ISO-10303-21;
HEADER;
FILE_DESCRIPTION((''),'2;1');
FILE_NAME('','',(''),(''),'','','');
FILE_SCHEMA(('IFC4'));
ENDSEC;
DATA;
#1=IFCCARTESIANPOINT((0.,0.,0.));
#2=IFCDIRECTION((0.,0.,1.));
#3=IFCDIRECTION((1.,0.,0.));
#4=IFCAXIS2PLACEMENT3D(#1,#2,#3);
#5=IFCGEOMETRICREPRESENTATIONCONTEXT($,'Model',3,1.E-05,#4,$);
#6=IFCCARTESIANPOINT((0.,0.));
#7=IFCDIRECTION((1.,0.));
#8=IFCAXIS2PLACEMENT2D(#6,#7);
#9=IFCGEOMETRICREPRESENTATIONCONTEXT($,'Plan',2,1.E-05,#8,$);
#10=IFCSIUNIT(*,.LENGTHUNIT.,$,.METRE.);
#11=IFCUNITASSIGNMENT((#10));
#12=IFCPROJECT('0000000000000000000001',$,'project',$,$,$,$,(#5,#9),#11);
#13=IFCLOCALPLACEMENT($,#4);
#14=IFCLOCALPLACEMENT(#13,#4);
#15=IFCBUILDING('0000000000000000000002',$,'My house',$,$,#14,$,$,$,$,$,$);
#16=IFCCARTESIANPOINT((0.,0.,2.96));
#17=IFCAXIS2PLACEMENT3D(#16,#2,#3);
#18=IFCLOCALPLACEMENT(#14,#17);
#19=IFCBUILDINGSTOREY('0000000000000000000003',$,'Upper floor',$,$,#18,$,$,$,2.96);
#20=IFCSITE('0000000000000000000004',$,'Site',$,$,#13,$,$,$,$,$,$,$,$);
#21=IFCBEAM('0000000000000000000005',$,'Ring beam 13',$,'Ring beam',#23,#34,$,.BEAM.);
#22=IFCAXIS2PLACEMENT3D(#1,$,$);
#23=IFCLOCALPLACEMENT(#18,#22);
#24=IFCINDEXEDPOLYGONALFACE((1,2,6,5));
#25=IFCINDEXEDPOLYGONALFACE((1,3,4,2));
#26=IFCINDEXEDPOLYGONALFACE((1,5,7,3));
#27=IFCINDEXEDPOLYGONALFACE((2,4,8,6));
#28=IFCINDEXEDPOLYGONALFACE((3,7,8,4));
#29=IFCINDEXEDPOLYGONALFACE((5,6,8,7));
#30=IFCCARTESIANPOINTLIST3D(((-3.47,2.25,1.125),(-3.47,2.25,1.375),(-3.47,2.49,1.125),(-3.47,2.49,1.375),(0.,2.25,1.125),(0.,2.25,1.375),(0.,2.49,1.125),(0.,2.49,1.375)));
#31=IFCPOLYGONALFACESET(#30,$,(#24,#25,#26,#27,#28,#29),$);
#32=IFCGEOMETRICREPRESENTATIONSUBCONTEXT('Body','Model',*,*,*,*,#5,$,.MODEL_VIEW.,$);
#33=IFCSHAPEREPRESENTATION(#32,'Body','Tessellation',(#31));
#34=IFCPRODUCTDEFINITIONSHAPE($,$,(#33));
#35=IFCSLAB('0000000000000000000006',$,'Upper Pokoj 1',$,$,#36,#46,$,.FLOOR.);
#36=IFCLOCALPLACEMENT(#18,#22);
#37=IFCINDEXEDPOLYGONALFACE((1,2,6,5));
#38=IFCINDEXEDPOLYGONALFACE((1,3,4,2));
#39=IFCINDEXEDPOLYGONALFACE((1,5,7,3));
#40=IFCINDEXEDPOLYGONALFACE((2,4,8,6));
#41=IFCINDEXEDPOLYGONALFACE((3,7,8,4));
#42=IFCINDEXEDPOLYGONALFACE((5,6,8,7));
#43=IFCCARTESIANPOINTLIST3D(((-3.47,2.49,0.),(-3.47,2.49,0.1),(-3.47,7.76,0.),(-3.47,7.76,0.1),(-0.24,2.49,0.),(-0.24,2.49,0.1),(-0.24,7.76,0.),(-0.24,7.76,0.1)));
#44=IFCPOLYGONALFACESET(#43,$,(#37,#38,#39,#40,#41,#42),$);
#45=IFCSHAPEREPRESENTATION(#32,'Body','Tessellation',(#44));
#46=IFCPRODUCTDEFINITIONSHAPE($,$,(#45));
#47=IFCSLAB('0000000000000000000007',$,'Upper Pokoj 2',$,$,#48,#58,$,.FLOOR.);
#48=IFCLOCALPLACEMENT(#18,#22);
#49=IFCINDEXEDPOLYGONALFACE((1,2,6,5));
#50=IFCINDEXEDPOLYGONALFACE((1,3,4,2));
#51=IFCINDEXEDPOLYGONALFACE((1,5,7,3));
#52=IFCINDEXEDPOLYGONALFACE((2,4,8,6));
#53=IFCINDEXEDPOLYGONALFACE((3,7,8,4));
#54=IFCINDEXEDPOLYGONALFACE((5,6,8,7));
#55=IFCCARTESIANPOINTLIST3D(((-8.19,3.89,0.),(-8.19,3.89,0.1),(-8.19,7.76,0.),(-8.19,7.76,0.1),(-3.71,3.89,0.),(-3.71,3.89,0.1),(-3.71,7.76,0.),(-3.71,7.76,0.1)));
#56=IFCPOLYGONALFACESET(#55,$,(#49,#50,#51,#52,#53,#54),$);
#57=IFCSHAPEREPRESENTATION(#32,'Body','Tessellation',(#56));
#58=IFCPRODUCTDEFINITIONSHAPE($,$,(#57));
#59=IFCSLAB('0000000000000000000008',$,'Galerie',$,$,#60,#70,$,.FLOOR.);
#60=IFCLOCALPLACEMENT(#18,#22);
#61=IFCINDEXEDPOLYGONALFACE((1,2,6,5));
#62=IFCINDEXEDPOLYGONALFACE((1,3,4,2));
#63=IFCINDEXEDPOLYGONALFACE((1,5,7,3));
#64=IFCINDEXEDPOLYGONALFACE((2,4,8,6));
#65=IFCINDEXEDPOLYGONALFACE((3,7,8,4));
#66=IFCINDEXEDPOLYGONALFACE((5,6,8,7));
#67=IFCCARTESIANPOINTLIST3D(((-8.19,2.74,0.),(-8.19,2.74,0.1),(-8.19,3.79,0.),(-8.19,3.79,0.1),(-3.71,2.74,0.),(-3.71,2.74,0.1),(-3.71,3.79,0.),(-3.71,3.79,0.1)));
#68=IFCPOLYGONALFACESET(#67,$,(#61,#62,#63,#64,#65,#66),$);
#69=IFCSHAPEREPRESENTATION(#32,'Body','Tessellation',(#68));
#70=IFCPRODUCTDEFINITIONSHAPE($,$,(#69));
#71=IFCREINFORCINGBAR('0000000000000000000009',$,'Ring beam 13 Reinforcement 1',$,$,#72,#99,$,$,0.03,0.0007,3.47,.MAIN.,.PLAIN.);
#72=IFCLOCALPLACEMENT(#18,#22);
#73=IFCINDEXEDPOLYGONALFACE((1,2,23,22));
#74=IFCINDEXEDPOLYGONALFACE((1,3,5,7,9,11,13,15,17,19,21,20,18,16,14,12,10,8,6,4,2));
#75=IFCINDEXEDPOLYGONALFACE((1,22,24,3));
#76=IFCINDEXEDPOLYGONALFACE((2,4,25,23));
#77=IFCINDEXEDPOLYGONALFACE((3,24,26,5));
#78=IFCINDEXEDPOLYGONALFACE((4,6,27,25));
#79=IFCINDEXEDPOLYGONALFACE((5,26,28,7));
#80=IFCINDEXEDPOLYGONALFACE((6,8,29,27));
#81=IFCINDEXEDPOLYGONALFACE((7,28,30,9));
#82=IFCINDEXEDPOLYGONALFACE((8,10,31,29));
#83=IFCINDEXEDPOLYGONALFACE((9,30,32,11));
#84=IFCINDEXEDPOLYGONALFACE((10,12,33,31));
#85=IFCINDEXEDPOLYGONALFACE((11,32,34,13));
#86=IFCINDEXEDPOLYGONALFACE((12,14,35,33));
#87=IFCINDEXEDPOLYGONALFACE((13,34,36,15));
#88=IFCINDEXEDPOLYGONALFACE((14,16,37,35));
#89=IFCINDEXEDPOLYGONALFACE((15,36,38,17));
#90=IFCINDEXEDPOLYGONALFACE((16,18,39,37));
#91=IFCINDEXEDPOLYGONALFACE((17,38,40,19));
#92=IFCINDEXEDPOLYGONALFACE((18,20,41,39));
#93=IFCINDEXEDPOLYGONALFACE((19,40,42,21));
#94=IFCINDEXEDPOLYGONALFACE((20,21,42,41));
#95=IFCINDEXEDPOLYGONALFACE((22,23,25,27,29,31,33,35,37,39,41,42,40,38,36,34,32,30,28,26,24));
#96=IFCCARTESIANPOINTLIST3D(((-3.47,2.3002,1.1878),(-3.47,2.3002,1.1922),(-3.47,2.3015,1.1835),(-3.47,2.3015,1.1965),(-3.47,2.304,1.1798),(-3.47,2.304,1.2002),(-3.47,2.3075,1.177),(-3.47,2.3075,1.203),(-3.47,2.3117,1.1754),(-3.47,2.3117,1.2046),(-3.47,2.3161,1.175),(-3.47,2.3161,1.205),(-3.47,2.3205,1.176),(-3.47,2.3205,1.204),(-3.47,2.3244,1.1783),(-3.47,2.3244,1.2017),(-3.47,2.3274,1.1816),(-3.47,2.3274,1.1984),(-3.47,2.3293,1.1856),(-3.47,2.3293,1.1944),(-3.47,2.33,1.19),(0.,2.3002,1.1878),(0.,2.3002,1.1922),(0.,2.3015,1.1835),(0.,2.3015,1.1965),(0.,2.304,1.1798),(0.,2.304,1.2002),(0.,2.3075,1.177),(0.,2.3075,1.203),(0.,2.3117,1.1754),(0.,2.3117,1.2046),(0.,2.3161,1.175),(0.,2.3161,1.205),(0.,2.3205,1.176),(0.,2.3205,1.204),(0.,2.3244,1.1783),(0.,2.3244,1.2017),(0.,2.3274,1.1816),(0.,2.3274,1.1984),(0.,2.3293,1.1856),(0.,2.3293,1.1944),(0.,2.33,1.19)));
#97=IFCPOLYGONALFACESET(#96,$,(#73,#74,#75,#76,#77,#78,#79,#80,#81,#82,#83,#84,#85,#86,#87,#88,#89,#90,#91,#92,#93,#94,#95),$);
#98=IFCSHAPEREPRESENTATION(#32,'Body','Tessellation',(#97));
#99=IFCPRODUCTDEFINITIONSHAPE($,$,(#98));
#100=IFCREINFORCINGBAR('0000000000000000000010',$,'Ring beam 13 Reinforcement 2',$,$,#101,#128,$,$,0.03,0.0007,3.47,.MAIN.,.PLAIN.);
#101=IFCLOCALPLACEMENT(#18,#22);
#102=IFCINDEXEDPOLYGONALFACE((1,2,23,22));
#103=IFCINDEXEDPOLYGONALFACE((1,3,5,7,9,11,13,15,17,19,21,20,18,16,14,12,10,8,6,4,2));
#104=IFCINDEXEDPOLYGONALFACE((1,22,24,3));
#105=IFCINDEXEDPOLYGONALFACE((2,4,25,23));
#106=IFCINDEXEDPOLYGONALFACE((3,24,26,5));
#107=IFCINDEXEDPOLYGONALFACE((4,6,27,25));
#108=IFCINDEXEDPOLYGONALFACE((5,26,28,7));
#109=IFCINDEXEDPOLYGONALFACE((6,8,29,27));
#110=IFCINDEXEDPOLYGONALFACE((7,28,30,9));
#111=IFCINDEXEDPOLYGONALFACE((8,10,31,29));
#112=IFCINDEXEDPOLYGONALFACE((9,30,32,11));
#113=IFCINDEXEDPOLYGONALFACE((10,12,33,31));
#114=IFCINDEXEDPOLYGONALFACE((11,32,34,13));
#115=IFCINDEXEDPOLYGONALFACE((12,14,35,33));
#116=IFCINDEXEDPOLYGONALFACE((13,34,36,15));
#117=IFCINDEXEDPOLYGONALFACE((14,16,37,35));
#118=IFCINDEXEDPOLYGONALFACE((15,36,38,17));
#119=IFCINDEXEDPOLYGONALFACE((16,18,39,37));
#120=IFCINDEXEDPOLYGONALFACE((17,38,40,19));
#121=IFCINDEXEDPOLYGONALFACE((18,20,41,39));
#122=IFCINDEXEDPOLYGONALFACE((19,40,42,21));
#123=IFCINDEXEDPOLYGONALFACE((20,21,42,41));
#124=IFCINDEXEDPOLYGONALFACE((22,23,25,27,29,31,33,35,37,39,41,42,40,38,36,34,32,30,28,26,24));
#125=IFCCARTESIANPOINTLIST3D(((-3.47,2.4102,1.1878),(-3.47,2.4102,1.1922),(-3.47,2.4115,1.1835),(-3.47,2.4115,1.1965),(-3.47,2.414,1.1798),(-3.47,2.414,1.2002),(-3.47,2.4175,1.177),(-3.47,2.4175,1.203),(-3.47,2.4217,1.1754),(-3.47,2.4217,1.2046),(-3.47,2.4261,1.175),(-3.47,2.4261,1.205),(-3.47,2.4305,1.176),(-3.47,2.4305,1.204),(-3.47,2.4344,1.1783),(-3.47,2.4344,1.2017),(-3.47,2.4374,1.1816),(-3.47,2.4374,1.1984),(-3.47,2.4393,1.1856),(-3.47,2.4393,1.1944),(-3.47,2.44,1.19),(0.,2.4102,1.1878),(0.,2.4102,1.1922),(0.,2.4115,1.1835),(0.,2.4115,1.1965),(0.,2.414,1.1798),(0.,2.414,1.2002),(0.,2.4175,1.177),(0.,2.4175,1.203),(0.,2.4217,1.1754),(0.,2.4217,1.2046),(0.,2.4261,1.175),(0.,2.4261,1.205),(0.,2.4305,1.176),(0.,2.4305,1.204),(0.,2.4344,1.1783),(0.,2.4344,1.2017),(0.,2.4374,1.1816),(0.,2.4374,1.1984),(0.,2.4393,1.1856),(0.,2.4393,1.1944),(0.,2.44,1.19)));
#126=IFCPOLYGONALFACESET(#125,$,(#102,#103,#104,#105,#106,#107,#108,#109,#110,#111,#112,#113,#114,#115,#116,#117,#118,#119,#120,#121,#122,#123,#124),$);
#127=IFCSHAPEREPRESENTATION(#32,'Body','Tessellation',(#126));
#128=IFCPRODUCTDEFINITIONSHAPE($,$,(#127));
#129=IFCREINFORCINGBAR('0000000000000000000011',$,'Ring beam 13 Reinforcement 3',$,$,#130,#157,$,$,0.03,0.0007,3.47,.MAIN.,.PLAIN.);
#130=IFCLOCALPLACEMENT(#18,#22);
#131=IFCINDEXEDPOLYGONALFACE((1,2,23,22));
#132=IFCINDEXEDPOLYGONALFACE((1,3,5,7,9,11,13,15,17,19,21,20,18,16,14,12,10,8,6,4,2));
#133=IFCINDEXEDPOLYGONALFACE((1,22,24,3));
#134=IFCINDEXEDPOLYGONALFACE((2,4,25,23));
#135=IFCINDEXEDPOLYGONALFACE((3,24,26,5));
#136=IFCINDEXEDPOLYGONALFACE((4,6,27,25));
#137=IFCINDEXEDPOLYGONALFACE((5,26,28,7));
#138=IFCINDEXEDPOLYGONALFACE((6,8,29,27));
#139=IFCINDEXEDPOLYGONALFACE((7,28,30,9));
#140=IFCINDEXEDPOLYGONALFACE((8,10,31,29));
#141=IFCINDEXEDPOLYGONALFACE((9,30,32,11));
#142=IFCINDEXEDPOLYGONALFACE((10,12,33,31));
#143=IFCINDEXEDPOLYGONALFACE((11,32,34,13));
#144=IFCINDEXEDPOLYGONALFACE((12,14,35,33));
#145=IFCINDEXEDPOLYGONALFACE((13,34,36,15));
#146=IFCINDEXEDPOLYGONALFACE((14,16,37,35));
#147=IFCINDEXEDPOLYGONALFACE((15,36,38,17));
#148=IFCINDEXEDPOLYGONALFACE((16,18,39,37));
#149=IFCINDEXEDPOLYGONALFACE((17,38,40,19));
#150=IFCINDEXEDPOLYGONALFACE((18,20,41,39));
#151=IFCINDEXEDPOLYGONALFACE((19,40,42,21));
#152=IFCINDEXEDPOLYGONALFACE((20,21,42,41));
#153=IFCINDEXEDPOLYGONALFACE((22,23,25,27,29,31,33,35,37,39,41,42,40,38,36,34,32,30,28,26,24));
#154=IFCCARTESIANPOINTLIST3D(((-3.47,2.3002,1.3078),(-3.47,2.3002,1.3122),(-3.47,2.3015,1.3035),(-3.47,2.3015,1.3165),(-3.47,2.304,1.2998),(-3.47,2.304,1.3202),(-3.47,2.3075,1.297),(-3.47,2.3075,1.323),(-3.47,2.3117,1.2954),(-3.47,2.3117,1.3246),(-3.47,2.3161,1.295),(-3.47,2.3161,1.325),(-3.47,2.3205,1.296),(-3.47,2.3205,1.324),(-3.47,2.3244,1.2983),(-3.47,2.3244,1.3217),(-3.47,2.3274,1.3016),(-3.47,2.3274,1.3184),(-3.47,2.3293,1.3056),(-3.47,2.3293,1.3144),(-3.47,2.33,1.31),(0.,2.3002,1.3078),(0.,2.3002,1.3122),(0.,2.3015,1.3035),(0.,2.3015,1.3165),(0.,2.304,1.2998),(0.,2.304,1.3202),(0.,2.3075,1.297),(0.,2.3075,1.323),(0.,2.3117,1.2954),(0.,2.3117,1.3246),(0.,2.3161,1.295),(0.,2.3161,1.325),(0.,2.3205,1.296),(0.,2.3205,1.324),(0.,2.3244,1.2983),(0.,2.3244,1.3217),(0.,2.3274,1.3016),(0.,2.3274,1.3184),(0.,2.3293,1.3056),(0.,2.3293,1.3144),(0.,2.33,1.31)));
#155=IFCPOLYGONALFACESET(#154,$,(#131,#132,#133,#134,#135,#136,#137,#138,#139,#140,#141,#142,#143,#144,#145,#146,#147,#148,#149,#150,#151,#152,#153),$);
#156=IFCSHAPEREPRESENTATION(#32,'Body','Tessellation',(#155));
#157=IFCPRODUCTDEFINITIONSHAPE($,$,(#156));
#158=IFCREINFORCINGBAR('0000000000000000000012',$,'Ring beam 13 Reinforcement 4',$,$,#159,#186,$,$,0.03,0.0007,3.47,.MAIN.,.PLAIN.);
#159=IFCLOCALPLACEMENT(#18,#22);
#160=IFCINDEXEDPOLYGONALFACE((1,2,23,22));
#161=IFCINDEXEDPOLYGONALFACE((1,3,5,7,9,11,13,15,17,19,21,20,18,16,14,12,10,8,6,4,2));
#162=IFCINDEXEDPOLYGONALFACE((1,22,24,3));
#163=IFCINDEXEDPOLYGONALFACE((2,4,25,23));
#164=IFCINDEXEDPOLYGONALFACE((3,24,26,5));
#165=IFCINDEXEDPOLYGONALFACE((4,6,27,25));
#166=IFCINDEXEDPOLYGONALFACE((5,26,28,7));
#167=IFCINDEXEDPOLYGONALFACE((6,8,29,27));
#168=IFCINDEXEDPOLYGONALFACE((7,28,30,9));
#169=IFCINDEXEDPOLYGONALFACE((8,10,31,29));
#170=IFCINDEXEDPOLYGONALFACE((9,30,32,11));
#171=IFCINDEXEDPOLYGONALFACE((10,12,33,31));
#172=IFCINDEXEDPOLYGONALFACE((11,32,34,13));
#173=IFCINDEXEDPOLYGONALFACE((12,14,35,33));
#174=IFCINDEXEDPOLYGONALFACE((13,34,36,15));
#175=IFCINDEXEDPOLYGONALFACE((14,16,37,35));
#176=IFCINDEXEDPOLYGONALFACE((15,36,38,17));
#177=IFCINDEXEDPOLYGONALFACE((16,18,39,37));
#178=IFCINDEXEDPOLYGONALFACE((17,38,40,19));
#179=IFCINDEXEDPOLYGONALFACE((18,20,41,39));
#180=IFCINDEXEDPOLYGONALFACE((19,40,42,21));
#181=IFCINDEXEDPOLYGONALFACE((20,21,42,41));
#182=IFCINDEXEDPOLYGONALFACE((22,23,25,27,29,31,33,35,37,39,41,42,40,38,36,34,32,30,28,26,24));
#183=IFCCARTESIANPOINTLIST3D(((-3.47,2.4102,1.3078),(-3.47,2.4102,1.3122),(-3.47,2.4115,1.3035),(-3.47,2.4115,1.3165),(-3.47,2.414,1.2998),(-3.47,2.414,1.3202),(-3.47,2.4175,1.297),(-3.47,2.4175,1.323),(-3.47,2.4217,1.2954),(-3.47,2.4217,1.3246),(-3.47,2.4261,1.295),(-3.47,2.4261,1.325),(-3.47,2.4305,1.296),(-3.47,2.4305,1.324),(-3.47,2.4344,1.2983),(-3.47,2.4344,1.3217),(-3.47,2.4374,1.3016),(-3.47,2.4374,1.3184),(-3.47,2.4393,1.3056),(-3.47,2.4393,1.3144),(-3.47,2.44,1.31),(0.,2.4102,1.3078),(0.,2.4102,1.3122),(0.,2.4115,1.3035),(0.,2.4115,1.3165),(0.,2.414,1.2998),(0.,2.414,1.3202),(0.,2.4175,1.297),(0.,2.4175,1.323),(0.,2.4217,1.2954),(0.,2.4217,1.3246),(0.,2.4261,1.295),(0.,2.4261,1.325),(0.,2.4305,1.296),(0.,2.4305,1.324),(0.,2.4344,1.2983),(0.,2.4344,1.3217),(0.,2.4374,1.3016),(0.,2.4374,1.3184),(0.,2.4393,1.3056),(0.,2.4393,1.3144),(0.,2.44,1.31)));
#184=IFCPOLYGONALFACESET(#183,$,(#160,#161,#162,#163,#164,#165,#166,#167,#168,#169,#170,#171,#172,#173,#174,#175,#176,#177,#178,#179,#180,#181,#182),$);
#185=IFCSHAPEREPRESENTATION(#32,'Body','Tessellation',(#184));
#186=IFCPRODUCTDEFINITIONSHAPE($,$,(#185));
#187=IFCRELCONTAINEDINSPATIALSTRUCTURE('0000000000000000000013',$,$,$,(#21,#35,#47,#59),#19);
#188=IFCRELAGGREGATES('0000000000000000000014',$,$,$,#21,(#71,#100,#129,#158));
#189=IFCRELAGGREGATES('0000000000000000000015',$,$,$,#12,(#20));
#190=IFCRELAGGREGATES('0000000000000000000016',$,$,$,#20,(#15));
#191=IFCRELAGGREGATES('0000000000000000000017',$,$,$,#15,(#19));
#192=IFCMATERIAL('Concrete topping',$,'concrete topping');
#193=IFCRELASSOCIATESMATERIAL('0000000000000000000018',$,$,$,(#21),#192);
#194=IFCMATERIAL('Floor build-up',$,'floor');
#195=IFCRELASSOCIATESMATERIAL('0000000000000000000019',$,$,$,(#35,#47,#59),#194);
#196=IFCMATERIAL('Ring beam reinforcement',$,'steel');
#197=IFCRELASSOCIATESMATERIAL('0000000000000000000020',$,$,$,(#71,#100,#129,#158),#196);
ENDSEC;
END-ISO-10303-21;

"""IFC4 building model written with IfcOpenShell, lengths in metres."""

from ifc_helpers import new_model, si_unit, frame, origin_with_axes, origin_2d, origin_2d_with_axis, place, context, subcontext, project, spatial, indexed_curve, circle_curve, rectangle, outline, extrude, source, transform, mapped, material, element, aggregate, save


model = new_model("IFC4")

# Units and contexts
model_context = context("Model", 3, precision=1e-05, world=origin_with_axes())
plan_context = context("Plan", 2, precision=1e-05, world=origin_2d_with_axis())
body_context_1 = subcontext(model_context, "Body", "Model", "MODEL_VIEW")
ifc_project = project(units=[si_unit("LENGTHUNIT", "METRE")], contexts=[model_context, plan_context])

# Site, building, storey
site_placement = place(None, origin_with_axes())
site = spatial("IfcSite", under=ifc_project, at=site_placement, Name="Site")
building_placement = place(site_placement, origin_with_axes())
building = spatial("IfcBuilding", under=site, at=building_placement, Name="My house")
storey_placement = place(building_placement, frame((0.0, 0.0, 2.96), z_axis=(0.0, 0.0, 1.0), x_axis=(1.0, 0.0, 0.0)))
storey = spatial("IfcBuildingStorey", under=building, at=storey_placement, Name="Upper floor", Elevation=2.96)

# Beam
ifc_material_1 = material(Name="Concrete topping", Category="concrete topping")
shared_shape_1 = source(origin_with_axes(), body_context_1, "Body", "SweptSolid", [
    extrude(rectangle(XDim=0.24, YDim=0.25), frame((0.0, 0.0, 0.0), z_axis=(1.0, 0.0, 0.0), x_axis=(0.0, 1.0, 0.0)), (0.0, 0.0, 1.0), 3.47),
])
beam_1_placement = place(storey_placement, frame((0.0, 2.37, 1.25), z_axis=(0.0, 0.0, 1.0), x_axis=(1.0, 0.0, 0.0)))
beam_1 = element("IfcBeam", 1, at=beam_1_placement, inside=storey, material=ifc_material_1, Name="Ring beam 13", ObjectType="Ring beam", PredefinedType="BEAM", context=body_context_1, shape_type="MappedRepresentation", body=[
    mapped(shared_shape_1, transform((0.0, 0.0, 0.0), x_axis=(-1.0, 0.0, 0.0), y_axis=(0.0, 1.0, 0.0), z_axis=(0.0, 0.0, 1.0), scale=1.0)),
])

# Slabs
ifc_material_2 = material(Name="Floor build-up", Category="floor")
shared_shape_2 = source(origin_with_axes(), body_context_1, "Body", "SweptSolid", [
    extrude(outline(indexed_curve([(0.24, 2.49), (3.47, 2.49), (3.47, 7.76), (0.24, 7.76)])), None, (0.0, 0.0, 1.0), 0.1),
])
slab_1_placement = place(storey_placement, origin_with_axes())
element("IfcSlab", 2, at=slab_1_placement, inside=storey, material=ifc_material_2, Name="Upper Pokoj 1", PredefinedType="FLOOR", context=body_context_1, shape_type="MappedRepresentation", body=[
    mapped(shared_shape_2, transform((0.0, 0.0, 0.0), x_axis=(-1.0, 0.0, 0.0), y_axis=(0.0, 1.0, 0.0), z_axis=(0.0, 0.0, 1.0), scale=1.0)),
])
shared_shape_3 = source(origin_with_axes(), body_context_1, "Body", "SweptSolid", [
    extrude(outline(indexed_curve([(3.71, 3.89), (8.19, 3.89), (8.19, 7.76), (3.71, 7.76)])), None, (0.0, 0.0, 1.0), 0.1),
])
slab_2_placement = place(storey_placement, origin_with_axes())
element("IfcSlab", 3, at=slab_2_placement, inside=storey, material=ifc_material_2, Name="Upper Pokoj 2", PredefinedType="FLOOR", context=body_context_1, shape_type="MappedRepresentation", body=[
    mapped(shared_shape_3, transform((0.0, 0.0, 0.0), x_axis=(-1.0, 0.0, 0.0), y_axis=(0.0, 1.0, 0.0), z_axis=(0.0, 0.0, 1.0), scale=1.0)),
])
shared_shape_4 = source(origin_with_axes(), body_context_1, "Body", "SweptSolid", [
    extrude(outline(indexed_curve([(3.71, 2.74), (8.19, 2.74), (8.19, 3.79), (3.71, 3.79)])), None, (0.0, 0.0, 1.0), 0.1),
])
slab_3_placement = place(storey_placement, origin_with_axes())
element("IfcSlab", 4, at=slab_3_placement, inside=storey, material=ifc_material_2, Name="Galerie", PredefinedType="FLOOR", context=body_context_1, shape_type="MappedRepresentation", body=[
    mapped(shared_shape_4, transform((0.0, 0.0, 0.0), x_axis=(-1.0, 0.0, 0.0), y_axis=(0.0, 1.0, 0.0), z_axis=(0.0, 0.0, 1.0), scale=1.0)),
])

# Reinforcing bars
ifc_material_3 = material(Name="Ring beam reinforcement", Category="steel")
shared_shape_5 = source(origin_with_axes(), body_context_1, "Body", "SweptSolid", [
    extrude(outline(circle_curve(origin_2d(), 0.015)), frame((0.0, 0.0, 0.0), z_axis=(1.0, 0.0, 0.0), x_axis=(0.0, 1.0, 0.0)), (0.0, 0.0, 1.0), 3.47),
])
reinforcing_bar_1_placement = place(beam_1_placement, frame((0.0, -0.055, -0.06), z_axis=(0.0, 0.0, 1.0), x_axis=(1.0, 0.0, 0.0)))
reinforcing_bar_1 = element("IfcReinforcingBar", 5, at=reinforcing_bar_1_placement, material=ifc_material_3, Name="Ring beam 13 Reinforcement 1", BarLength=3.47, BarSurface="PLAIN", CrossSectionArea=0.0007, NominalDiameter=0.03, PredefinedType="MAIN", context=body_context_1, shape_type="MappedRepresentation", body=[
    mapped(shared_shape_5, transform((0.0, 0.0, 0.0), x_axis=(-1.0, 0.0, 0.0), y_axis=(0.0, 1.0, 0.0), z_axis=(0.0, 0.0, 1.0), scale=1.0)),
])
shared_shape_6 = source(origin_with_axes(), body_context_1, "Body", "SweptSolid", [
    extrude(outline(circle_curve(origin_2d(), 0.015)), frame((0.0, 0.0, 0.0), z_axis=(1.0, 0.0, 0.0), x_axis=(0.0, 1.0, 0.0)), (0.0, 0.0, 1.0), 3.47),
])
reinforcing_bar_2_placement = place(beam_1_placement, frame((0.0, 0.055, -0.06), z_axis=(0.0, 0.0, 1.0), x_axis=(1.0, 0.0, 0.0)))
reinforcing_bar_2 = element("IfcReinforcingBar", 6, at=reinforcing_bar_2_placement, material=ifc_material_3, Name="Ring beam 13 Reinforcement 2", BarLength=3.47, BarSurface="PLAIN", CrossSectionArea=0.0007, NominalDiameter=0.03, PredefinedType="MAIN", context=body_context_1, shape_type="MappedRepresentation", body=[
    mapped(shared_shape_6, transform((0.0, 0.0, 0.0), x_axis=(-1.0, 0.0, 0.0), y_axis=(0.0, 1.0, 0.0), z_axis=(0.0, 0.0, 1.0), scale=1.0)),
])
shared_shape_7 = source(origin_with_axes(), body_context_1, "Body", "SweptSolid", [
    extrude(outline(circle_curve(origin_2d(), 0.015)), frame((0.0, 0.0, 0.0), z_axis=(1.0, 0.0, 0.0), x_axis=(0.0, 1.0, 0.0)), (0.0, 0.0, 1.0), 3.47),
])
reinforcing_bar_3_placement = place(beam_1_placement, frame((0.0, -0.055, 0.06), z_axis=(0.0, 0.0, 1.0), x_axis=(1.0, 0.0, 0.0)))
reinforcing_bar_3 = element("IfcReinforcingBar", 7, at=reinforcing_bar_3_placement, material=ifc_material_3, Name="Ring beam 13 Reinforcement 3", BarLength=3.47, BarSurface="PLAIN", CrossSectionArea=0.0007, NominalDiameter=0.03, PredefinedType="MAIN", context=body_context_1, shape_type="MappedRepresentation", body=[
    mapped(shared_shape_7, transform((0.0, 0.0, 0.0), x_axis=(-1.0, 0.0, 0.0), y_axis=(0.0, 1.0, 0.0), z_axis=(0.0, 0.0, 1.0), scale=1.0)),
])
shared_shape_8 = source(origin_with_axes(), body_context_1, "Body", "SweptSolid", [
    extrude(outline(circle_curve(origin_2d(), 0.015)), frame((0.0, 0.0, 0.0), z_axis=(1.0, 0.0, 0.0), x_axis=(0.0, 1.0, 0.0)), (0.0, 0.0, 1.0), 3.47),
])
reinforcing_bar_4_placement = place(beam_1_placement, frame((0.0, 0.055, 0.06), z_axis=(0.0, 0.0, 1.0), x_axis=(1.0, 0.0, 0.0)))
reinforcing_bar_4 = element("IfcReinforcingBar", 8, at=reinforcing_bar_4_placement, material=ifc_material_3, Name="Ring beam 13 Reinforcement 4", BarLength=3.47, BarSurface="PLAIN", CrossSectionArea=0.0007, NominalDiameter=0.03, PredefinedType="MAIN", context=body_context_1, shape_type="MappedRepresentation", body=[
    mapped(shared_shape_8, transform((0.0, 0.0, 0.0), x_axis=(-1.0, 0.0, 0.0), y_axis=(0.0, 1.0, 0.0), z_axis=(0.0, 0.0, 1.0), scale=1.0)),
])
aggregate(beam_1, [reinforcing_bar_1, reinforcing_bar_2, reinforcing_bar_3, reinforcing_bar_4])

save(model, "model.ifc")
